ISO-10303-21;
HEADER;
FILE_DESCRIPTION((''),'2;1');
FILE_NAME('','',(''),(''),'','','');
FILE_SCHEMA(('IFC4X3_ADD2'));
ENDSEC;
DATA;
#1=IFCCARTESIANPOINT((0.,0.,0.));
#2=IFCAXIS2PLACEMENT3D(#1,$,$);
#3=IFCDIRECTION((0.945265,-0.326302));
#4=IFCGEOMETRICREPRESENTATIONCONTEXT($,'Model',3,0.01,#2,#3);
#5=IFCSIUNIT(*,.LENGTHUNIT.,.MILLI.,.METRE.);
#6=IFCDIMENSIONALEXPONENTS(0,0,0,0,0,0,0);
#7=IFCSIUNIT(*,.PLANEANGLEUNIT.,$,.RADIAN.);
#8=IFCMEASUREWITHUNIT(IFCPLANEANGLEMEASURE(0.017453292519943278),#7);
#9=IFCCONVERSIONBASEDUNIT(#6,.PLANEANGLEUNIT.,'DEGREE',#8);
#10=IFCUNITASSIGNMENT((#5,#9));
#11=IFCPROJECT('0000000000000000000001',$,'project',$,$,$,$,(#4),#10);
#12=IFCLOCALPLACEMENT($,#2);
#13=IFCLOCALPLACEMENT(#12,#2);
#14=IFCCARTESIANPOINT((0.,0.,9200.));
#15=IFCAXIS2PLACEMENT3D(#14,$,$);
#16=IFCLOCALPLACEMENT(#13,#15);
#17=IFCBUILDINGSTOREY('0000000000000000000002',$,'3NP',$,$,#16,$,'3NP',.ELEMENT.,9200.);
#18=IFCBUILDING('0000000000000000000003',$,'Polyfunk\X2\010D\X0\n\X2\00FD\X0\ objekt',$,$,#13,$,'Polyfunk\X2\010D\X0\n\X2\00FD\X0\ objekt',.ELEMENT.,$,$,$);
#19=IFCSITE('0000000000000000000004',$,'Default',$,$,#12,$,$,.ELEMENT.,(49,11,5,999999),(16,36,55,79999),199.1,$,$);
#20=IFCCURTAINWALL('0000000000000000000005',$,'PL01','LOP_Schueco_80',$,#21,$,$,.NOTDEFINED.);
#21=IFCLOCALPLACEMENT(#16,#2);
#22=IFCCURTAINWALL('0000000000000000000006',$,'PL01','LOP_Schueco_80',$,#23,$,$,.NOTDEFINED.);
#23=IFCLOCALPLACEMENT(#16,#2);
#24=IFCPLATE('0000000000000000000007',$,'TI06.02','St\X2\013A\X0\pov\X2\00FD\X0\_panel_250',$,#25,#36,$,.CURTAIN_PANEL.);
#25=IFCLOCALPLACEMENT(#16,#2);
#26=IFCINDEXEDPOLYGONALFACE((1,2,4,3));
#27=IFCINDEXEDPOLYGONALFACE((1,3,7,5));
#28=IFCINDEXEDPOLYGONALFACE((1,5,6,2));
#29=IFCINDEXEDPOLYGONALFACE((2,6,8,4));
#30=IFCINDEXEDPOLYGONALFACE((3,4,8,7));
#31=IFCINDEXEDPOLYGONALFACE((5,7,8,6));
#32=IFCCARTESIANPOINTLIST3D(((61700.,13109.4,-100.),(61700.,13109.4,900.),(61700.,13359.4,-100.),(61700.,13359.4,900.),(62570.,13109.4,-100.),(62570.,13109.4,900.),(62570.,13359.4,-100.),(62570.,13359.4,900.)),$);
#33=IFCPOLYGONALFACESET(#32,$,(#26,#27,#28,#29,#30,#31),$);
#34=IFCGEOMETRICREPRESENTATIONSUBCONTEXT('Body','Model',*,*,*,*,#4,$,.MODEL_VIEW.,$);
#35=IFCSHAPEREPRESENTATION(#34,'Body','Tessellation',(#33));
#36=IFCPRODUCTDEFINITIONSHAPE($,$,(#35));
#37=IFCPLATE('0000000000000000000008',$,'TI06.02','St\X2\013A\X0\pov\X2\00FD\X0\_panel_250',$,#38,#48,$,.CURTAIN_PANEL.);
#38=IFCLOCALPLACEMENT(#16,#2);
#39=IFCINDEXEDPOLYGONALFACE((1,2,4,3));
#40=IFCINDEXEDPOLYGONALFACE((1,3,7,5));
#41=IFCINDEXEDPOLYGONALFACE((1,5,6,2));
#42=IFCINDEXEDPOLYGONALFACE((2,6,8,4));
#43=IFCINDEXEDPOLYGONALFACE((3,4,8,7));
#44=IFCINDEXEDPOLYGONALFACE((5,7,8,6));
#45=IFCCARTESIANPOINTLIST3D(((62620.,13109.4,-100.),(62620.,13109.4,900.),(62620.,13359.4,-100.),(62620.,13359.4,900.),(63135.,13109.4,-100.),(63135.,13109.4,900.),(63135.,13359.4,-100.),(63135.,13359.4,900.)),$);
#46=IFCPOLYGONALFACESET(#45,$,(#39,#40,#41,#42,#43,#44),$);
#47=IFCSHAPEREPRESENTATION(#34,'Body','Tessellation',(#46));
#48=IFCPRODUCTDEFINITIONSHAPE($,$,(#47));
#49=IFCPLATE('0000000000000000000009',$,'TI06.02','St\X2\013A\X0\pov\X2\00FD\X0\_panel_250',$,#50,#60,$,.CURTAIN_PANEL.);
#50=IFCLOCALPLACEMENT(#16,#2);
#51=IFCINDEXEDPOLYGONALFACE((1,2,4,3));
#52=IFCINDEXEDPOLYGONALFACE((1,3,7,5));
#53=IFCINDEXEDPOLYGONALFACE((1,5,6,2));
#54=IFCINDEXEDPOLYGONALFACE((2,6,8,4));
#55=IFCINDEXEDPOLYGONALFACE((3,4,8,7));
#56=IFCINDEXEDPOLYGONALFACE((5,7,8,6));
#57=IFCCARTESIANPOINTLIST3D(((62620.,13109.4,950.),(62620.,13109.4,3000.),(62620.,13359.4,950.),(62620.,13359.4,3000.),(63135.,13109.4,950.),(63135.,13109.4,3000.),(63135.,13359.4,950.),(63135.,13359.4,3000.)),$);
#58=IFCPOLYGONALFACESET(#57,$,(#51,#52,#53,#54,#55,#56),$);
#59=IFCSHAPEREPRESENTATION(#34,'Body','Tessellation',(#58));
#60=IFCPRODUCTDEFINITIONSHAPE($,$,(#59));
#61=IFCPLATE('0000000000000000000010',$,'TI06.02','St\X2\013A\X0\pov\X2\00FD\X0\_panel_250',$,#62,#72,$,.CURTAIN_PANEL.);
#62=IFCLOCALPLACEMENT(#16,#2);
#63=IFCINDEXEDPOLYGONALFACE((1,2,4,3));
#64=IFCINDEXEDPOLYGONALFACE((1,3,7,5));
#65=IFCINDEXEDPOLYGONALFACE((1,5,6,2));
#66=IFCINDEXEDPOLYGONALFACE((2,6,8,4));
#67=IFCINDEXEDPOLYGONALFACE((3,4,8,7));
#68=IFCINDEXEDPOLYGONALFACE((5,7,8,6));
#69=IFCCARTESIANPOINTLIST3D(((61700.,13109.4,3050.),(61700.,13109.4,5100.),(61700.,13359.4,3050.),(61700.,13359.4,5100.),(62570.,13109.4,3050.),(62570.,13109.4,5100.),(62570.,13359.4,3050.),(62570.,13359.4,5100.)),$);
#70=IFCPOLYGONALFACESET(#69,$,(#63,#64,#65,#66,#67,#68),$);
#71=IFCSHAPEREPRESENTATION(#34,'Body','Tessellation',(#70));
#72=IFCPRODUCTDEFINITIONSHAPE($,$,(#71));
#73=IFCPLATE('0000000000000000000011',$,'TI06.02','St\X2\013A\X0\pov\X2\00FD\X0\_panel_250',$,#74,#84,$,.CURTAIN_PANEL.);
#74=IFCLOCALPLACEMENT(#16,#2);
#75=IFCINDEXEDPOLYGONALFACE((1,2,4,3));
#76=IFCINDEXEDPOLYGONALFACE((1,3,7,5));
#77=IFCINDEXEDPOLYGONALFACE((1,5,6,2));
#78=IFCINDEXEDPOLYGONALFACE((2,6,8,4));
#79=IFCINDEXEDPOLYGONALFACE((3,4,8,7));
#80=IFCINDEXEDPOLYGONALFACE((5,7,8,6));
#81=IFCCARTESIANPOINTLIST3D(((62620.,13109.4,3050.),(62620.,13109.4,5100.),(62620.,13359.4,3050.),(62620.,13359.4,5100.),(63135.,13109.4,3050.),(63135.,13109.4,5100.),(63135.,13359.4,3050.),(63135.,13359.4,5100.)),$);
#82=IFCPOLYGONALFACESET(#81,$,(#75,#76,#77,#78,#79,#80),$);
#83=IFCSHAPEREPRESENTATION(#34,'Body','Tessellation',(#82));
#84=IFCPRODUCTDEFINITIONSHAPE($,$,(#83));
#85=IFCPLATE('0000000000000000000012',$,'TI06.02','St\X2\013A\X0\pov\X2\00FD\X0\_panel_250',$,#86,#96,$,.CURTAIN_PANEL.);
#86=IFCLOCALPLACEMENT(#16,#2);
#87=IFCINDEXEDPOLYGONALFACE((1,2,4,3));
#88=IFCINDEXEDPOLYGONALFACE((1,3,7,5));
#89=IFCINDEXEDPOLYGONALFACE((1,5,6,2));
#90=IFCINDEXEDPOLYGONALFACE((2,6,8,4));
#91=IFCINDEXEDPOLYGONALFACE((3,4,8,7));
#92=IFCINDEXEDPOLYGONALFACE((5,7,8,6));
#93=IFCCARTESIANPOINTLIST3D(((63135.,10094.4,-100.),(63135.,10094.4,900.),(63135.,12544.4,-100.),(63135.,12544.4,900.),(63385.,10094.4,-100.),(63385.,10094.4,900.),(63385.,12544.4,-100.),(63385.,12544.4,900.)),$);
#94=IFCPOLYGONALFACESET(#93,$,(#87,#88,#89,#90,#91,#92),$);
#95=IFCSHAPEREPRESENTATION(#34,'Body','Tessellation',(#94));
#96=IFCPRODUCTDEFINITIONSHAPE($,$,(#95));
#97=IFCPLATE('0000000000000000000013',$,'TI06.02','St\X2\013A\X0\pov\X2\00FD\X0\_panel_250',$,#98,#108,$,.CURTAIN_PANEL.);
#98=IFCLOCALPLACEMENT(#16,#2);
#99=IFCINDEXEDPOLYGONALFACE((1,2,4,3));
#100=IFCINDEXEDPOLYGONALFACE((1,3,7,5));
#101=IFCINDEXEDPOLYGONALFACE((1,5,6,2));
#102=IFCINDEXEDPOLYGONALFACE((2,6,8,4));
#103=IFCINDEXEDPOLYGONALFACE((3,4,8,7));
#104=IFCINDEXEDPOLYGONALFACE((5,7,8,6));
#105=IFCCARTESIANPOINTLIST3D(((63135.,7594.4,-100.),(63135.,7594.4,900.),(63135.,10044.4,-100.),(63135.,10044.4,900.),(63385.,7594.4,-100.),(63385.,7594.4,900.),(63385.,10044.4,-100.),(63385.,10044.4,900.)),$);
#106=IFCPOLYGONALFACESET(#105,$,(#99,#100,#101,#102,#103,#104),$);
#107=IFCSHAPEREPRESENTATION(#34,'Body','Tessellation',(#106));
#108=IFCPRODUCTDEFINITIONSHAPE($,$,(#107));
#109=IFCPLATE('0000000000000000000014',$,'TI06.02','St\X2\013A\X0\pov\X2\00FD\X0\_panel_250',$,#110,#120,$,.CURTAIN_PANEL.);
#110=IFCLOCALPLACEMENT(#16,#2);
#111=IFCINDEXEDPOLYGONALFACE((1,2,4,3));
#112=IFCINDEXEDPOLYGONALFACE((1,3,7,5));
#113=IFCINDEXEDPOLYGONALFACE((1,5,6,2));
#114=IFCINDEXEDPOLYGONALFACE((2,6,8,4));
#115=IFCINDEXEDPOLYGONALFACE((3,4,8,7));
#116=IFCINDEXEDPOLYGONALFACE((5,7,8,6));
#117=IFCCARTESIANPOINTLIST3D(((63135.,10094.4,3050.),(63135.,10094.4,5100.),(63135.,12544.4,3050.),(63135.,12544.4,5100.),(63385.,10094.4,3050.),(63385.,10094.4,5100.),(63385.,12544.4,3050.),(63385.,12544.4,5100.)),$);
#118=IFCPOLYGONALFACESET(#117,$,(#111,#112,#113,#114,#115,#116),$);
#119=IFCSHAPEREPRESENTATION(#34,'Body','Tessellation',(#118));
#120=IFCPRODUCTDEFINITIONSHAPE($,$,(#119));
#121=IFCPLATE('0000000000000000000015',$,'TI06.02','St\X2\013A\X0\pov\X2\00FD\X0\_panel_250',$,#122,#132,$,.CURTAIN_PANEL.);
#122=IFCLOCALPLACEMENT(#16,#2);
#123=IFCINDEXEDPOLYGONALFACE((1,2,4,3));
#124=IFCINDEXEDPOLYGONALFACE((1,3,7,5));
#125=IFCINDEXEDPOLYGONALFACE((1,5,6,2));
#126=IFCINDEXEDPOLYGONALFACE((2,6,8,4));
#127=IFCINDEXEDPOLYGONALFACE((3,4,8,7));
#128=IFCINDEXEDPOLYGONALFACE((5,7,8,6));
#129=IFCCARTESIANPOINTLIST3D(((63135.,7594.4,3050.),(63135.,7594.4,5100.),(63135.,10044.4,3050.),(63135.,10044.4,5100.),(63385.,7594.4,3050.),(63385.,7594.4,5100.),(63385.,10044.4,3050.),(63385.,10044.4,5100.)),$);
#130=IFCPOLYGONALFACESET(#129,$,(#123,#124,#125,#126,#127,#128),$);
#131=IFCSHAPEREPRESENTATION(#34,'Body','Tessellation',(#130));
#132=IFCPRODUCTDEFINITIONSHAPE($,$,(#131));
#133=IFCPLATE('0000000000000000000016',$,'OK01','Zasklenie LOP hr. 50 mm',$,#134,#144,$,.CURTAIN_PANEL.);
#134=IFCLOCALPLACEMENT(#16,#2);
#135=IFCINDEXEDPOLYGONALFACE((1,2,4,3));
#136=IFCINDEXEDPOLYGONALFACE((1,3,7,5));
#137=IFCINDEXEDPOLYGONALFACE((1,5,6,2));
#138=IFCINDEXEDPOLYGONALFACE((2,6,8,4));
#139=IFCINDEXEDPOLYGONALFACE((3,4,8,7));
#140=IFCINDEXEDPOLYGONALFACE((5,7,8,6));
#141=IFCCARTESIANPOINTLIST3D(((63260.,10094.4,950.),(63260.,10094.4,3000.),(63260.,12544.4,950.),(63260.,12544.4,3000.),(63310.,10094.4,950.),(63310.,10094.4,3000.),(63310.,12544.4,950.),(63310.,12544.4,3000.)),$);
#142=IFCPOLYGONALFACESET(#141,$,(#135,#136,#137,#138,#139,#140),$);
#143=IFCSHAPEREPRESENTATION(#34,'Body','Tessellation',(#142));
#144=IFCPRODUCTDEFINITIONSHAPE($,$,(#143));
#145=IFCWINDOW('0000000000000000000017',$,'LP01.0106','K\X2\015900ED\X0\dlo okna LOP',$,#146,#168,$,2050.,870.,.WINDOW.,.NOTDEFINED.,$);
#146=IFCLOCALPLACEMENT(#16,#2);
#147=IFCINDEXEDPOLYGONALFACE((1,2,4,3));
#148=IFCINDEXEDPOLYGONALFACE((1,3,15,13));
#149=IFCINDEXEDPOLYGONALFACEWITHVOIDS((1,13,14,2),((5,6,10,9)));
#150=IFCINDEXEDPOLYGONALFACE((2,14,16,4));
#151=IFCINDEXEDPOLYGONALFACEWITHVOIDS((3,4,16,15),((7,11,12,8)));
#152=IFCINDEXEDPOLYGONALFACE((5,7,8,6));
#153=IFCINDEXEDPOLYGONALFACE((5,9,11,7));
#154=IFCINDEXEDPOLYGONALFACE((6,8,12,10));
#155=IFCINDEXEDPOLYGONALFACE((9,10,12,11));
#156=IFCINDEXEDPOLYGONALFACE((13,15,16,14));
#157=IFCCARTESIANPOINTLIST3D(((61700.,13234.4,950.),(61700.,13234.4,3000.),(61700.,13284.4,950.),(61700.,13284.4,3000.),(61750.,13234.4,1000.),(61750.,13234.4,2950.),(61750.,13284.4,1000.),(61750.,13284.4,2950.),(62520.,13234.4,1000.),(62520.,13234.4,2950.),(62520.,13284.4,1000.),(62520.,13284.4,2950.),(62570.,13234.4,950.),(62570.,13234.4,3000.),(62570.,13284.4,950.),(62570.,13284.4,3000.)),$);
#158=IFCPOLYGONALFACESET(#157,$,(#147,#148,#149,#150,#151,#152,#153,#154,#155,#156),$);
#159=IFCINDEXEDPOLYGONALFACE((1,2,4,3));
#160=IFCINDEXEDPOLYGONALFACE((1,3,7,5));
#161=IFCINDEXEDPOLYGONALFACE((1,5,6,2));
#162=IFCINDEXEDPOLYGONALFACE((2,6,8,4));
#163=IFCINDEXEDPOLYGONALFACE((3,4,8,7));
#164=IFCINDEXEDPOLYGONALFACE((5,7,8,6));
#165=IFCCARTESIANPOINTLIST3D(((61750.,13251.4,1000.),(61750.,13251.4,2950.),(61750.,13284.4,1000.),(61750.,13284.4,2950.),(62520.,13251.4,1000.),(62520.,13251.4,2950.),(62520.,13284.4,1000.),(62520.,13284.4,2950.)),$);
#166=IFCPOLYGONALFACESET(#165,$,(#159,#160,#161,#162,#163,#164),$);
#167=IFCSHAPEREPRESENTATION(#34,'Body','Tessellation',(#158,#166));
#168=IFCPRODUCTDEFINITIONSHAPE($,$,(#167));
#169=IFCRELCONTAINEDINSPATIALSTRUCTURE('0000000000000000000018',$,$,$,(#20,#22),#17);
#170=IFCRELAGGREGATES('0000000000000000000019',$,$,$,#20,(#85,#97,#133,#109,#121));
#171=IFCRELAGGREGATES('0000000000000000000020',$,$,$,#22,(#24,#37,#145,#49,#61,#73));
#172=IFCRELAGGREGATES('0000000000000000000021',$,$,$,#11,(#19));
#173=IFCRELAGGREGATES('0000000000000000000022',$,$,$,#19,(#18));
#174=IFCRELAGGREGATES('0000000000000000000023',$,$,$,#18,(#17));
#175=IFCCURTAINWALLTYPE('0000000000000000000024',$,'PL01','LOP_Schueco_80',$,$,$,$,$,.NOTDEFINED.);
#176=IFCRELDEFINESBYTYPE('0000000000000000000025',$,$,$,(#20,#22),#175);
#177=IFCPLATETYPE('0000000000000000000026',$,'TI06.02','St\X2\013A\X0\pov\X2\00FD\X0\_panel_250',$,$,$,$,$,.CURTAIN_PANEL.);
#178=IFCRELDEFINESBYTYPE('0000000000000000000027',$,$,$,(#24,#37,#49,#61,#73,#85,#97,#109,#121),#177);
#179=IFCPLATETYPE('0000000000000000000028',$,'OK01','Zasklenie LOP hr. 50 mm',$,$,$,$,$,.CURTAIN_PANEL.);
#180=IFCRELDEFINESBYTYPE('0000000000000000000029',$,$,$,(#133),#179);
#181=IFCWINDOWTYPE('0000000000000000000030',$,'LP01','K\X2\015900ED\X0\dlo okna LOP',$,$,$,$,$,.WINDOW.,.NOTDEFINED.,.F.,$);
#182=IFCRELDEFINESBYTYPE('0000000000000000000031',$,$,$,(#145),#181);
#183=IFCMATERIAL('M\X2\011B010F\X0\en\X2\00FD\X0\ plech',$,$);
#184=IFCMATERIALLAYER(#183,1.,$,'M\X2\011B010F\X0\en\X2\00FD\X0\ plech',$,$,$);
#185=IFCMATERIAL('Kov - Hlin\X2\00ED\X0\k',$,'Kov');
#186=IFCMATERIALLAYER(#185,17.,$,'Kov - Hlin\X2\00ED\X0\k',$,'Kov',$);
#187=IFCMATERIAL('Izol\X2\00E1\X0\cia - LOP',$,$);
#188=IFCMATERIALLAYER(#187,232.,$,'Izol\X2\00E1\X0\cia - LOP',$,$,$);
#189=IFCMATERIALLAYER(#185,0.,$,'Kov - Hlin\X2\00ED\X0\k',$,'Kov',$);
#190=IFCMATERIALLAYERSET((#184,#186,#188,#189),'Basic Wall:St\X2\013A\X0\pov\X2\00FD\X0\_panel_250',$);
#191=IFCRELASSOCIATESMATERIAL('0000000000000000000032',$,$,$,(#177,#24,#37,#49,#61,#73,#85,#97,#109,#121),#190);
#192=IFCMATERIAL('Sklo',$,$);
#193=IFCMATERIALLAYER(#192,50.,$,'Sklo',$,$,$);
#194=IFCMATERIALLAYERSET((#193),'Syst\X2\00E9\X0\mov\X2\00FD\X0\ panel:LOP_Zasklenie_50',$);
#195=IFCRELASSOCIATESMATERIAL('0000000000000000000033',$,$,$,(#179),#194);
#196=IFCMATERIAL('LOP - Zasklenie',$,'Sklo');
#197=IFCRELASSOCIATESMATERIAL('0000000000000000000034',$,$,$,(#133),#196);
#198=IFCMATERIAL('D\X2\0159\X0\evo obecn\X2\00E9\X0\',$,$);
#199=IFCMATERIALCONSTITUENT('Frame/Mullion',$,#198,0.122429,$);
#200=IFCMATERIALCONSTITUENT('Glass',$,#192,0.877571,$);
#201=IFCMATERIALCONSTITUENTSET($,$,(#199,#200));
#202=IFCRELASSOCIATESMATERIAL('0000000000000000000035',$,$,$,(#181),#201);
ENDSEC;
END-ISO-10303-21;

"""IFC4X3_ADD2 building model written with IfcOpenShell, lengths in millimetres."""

from ifc_helpers import new_model, entity, si_unit, converted_unit, direction, frame, frame_2d, origin, origin_2d_with_axis, place, context, subcontext, project, spatial, polyline, rectangle, outline, extrude, source, transform, mapped, material, layer, layer_set, layer_usage, constituent, constituent_set, type_object, type_shapes, element, aggregate, save


model = new_model("IFC4X3_ADD2")

# Units and contexts
model_context = context("Model", 3, precision=0.01, world=origin(), true_north=direction((0.945265, -0.326302)))
body_context = subcontext(model_context, "Body", "Model", "MODEL_VIEW")
ifc_project = project(units=[si_unit("LENGTHUNIT", "METRE", prefix="MILLI"), converted_unit("PLANEANGLEUNIT", "DEGREE", entity("IfcPlaneAngleMeasure", 0.017453292519943278), si_unit("PLANEANGLEUNIT", "RADIAN"), dimensions=[0, 0, 0, 0, 0, 0, 0])], contexts=[model_context])

# Site, building, storey
site_placement = place(None, origin())
site = spatial("IfcSite", under=ifc_project, at=site_placement, Name="Default", CompositionType="ELEMENT", RefLatitude=(49, 11, 5, 999999), RefLongitude=(16, 36, 55, 79999), RefElevation=199.1)
building_placement = place(site_placement, origin())
building = spatial("IfcBuilding", under=site, at=building_placement, Name="Polyfunkčný objekt", LongName="Polyfunkčný objekt", CompositionType="ELEMENT")
storey_placement = place(building_placement, frame((0.0, 0.0, 9200.0)))
storey = spatial("IfcBuildingStorey", under=building, at=storey_placement, Name="3NP", LongName="3NP", CompositionType="ELEMENT", Elevation=9200.0)

# Curtain walls
curtain_wall_type = type_object("IfcCurtainWallType", Name="PL01", Description="LOP_Schueco_80", PredefinedType="NOTDEFINED")
curtain_wall_1_placement = place(storey_placement, frame((0.0, 0.0, -9200.0)))
curtain_wall_1 = element("IfcCurtainWall", 1, at=curtain_wall_1_placement, inside=storey, type_object=curtain_wall_type, Name="PL01", Description="LOP_Schueco_80", PredefinedType="NOTDEFINED")
curtain_wall_2_placement = place(storey_placement, frame((0.0, 0.0, -9200.0)))
curtain_wall_2 = element("IfcCurtainWall", 2, at=curtain_wall_2_placement, inside=storey, type_object=curtain_wall_type, Name="PL01", Description="LOP_Schueco_80", PredefinedType="NOTDEFINED")

# Plates
ifc_material_1 = material(Name="Měďený plech")
ifc_layer_1 = layer(ifc_material_1, 1.0, Name="Měďený plech")
ifc_material_2 = material(Name="Kov - Hliník", Category="Kov")
ifc_layer_2 = layer(ifc_material_2, 17.0, Name="Kov - Hliník", Category="Kov")
ifc_material_3 = material(Name="Izolácia - LOP")
ifc_layer_3 = layer(ifc_material_3, 232.0, Name="Izolácia - LOP")
ifc_layer_4 = layer(ifc_material_2, 0.0, Name="Kov - Hliník", Category="Kov")
ifc_layer_set_1 = layer_set([ifc_layer_1, ifc_layer_2, ifc_layer_3, ifc_layer_4], Name="Basic Wall:Stĺpový_panel_250")
ifc_layer_usage_1 = layer_usage(ifc_layer_set_1, "AXIS2", "NEGATIVE", 125.0)
plate_type_1 = type_object("IfcPlateType", Name="TI06.02", Description="Stĺpový_panel_250", PredefinedType="CURTAIN_PANEL", material=ifc_layer_set_1)
plate_1_placement = place(storey_placement, frame((61700.0, 13234.4, -100.0)))
plate_1 = element("IfcPlate", 3, at=plate_1_placement, type_object=plate_type_1, material=ifc_layer_usage_1, Name="TI06.02", Description="Stĺpový_panel_250", PredefinedType="CURTAIN_PANEL", context=body_context, shape_type="SweptSolid", body=[
    extrude(rectangle(XDim=250.0, YDim=870.0, at=frame_2d((0.0, 0.0), x_axis=(1.0, 0.0))), frame((435.0, 0.0, 0.0), z_axis=(0.0, 0.0, 1.0), x_axis=(0.0, 1.0, 0.0)), (0.0, 0.0, 1.0), 1000.0),
])
ifc_layer_usage_2 = layer_usage(ifc_layer_set_1, "AXIS2", "NEGATIVE", 125.0)
plate_2_placement = place(storey_placement, frame((62620.0, 13234.4, -100.0)))
plate_2 = element("IfcPlate", 4, at=plate_2_placement, type_object=plate_type_1, material=ifc_layer_usage_2, Name="TI06.02", Description="Stĺpový_panel_250", PredefinedType="CURTAIN_PANEL", context=body_context, shape_type="SweptSolid", body=[
    extrude(rectangle(XDim=250.0, YDim=515.0, at=frame_2d((0.0, 0.0), x_axis=(1.0, 0.0))), frame((257.5, 0.0, 0.0), z_axis=(0.0, 0.0, 1.0), x_axis=(0.0, 1.0, 0.0)), (0.0, 0.0, 1.0), 1000.0),
])
ifc_layer_usage_3 = layer_usage(ifc_layer_set_1, "AXIS2", "NEGATIVE", 125.0)
plate_3_placement = place(storey_placement, frame((62620.0, 13234.4, 950.0)))
plate_3 = element("IfcPlate", 5, at=plate_3_placement, type_object=plate_type_1, material=ifc_layer_usage_3, Name="TI06.02", Description="Stĺpový_panel_250", PredefinedType="CURTAIN_PANEL", context=body_context, shape_type="SweptSolid", body=[
    extrude(rectangle(XDim=250.0, YDim=515.0, at=frame_2d((0.0, 0.0), x_axis=(1.0, 0.0))), frame((257.5, 0.0, 0.0), z_axis=(0.0, 0.0, 1.0), x_axis=(0.0, 1.0, 0.0)), (0.0, 0.0, 1.0), 2050.0),
])
ifc_layer_usage_4 = layer_usage(ifc_layer_set_1, "AXIS2", "NEGATIVE", 125.0)
plate_4_placement = place(storey_placement, frame((61700.0, 13234.4, 3050.0)))
plate_4 = element("IfcPlate", 6, at=plate_4_placement, type_object=plate_type_1, material=ifc_layer_usage_4, Name="TI06.02", Description="Stĺpový_panel_250", PredefinedType="CURTAIN_PANEL", context=body_context, shape_type="SweptSolid", body=[
    extrude(rectangle(XDim=250.0, YDim=870.0, at=frame_2d((0.0, 0.0), x_axis=(1.0, 0.0))), frame((435.0, 0.0, 0.0), z_axis=(0.0, 0.0, 1.0), x_axis=(0.0, 1.0, 0.0)), (0.0, 0.0, 1.0), 2050.0),
])
ifc_layer_usage_5 = layer_usage(ifc_layer_set_1, "AXIS2", "NEGATIVE", 125.0)
plate_5_placement = place(storey_placement, frame((62620.0, 13234.4, 3050.0)))
plate_5 = element("IfcPlate", 7, at=plate_5_placement, type_object=plate_type_1, material=ifc_layer_usage_5, Name="TI06.02", Description="Stĺpový_panel_250", PredefinedType="CURTAIN_PANEL", context=body_context, shape_type="SweptSolid", body=[
    extrude(rectangle(XDim=250.0, YDim=515.0, at=frame_2d((0.0, 0.0), x_axis=(1.0, 0.0))), frame((257.5, 0.0, 0.0), z_axis=(0.0, 0.0, 1.0), x_axis=(0.0, 1.0, 0.0)), (0.0, 0.0, 1.0), 2050.0),
])
ifc_layer_usage_6 = layer_usage(ifc_layer_set_1, "AXIS2", "NEGATIVE", 125.0)
plate_6_placement = place(storey_placement, frame((63260.0, 12544.4, -100.0), z_axis=(0.0, 0.0, 1.0), x_axis=(0.0, -1.0, 0.0)))
plate_6 = element("IfcPlate", 8, at=plate_6_placement, type_object=plate_type_1, material=ifc_layer_usage_6, Name="TI06.02", Description="Stĺpový_panel_250", PredefinedType="CURTAIN_PANEL", context=body_context, shape_type="SweptSolid", body=[
    extrude(rectangle(XDim=250.0, YDim=2450.0, at=frame_2d((0.0, 0.0), x_axis=(1.0, 0.0))), frame((1225.0, 0.0, 0.0), z_axis=(0.0, 0.0, 1.0), x_axis=(0.0, 1.0, 0.0)), (0.0, 0.0, 1.0), 1000.0),
])
ifc_layer_usage_7 = layer_usage(ifc_layer_set_1, "AXIS2", "NEGATIVE", 125.0)
plate_7_placement = place(storey_placement, frame((63260.0, 10044.4, -100.0), z_axis=(0.0, 0.0, 1.0), x_axis=(0.0, -1.0, 0.0)))
plate_7 = element("IfcPlate", 9, at=plate_7_placement, type_object=plate_type_1, material=ifc_layer_usage_7, Name="TI06.02", Description="Stĺpový_panel_250", PredefinedType="CURTAIN_PANEL", context=body_context, shape_type="SweptSolid", body=[
    extrude(rectangle(XDim=250.0, YDim=2450.0, at=origin_2d_with_axis()), frame((1225.0, 0.0, 0.0), z_axis=(0.0, 0.0, 1.0), x_axis=(0.0, 1.0, 0.0)), (0.0, 0.0, 1.0), 1000.0),
])
ifc_layer_usage_8 = layer_usage(ifc_layer_set_1, "AXIS2", "NEGATIVE", 125.0)
plate_8_placement = place(storey_placement, frame((63260.0, 12544.4, 3050.0), z_axis=(0.0, 0.0, 1.0), x_axis=(0.0, -1.0, 0.0)))
plate_8 = element("IfcPlate", 10, at=plate_8_placement, type_object=plate_type_1, material=ifc_layer_usage_8, Name="TI06.02", Description="Stĺpový_panel_250", PredefinedType="CURTAIN_PANEL", context=body_context, shape_type="SweptSolid", body=[
    extrude(rectangle(XDim=250.0, YDim=2450.0, at=frame_2d((0.0, 0.0), x_axis=(1.0, 0.0))), frame((1225.0, 0.0, 0.0), z_axis=(0.0, 0.0, 1.0), x_axis=(0.0, 1.0, 0.0)), (0.0, 0.0, 1.0), 2050.0),
])
ifc_layer_usage_9 = layer_usage(ifc_layer_set_1, "AXIS2", "NEGATIVE", 125.0)
plate_9_placement = place(storey_placement, frame((63260.0, 10044.4, 3050.0), z_axis=(0.0, 0.0, 1.0), x_axis=(0.0, -1.0, 0.0)))
plate_9 = element("IfcPlate", 11, at=plate_9_placement, type_object=plate_type_1, material=ifc_layer_usage_9, Name="TI06.02", Description="Stĺpový_panel_250", PredefinedType="CURTAIN_PANEL", context=body_context, shape_type="SweptSolid", body=[
    extrude(rectangle(XDim=250.0, YDim=2450.0, at=frame_2d((0.0, 0.0), x_axis=(1.0, 0.0))), frame((1225.0, 0.0, 0.0), z_axis=(0.0, 0.0, 1.0), x_axis=(0.0, 1.0, 0.0)), (0.0, 0.0, 1.0), 2050.0),
])
ifc_material_4 = material(Name="LOP - Zasklenie", Category="Sklo")
ifc_material_5 = material(Name="Sklo")
ifc_layer_5 = layer(ifc_material_5, 50.0, Name="Sklo")
ifc_layer_set_2 = layer_set([ifc_layer_5], Name="Systémový panel:LOP_Zasklenie_50")
plate_type_2 = type_object("IfcPlateType", Name="OK01", Description="Zasklenie LOP hr. 50 mm", PredefinedType="CURTAIN_PANEL", material=ifc_layer_set_2)
shared_shape_1 = source(origin(), body_context, "Body", "SweptSolid", [
    extrude(rectangle(XDim=50.0, YDim=2450.0, at=origin_2d_with_axis()), frame((0.0, 25.0, 0.0), z_axis=(0.0, 0.0, 1.0), x_axis=(0.0, 1.0, 0.0)), (0.0, 0.0, 1.0), 2050.0),
])
type_shapes(plate_type_2, [shared_shape_1])
plate_10_placement = place(curtain_wall_1_placement, frame((63260.0, 11319.4, 10150.0), z_axis=(0.0, 0.0, 1.0), x_axis=(0.0, -1.0, 0.0)))
plate_10 = element("IfcPlate", 12, at=plate_10_placement, type_object=plate_type_2, material=ifc_material_4, Name="OK01", Description="Zasklenie LOP hr. 50 mm", PredefinedType="CURTAIN_PANEL", context=body_context, shape_type="MappedRepresentation", body=[
    mapped(shared_shape_1, transform((0.0, 0.0, 0.0), scale=1.0)),
])
aggregate(curtain_wall_1, [plate_6, plate_7, plate_10, plate_8, plate_9])

# Window
ifc_material_6 = material(Name="Dřevo obecné")
ifc_constituent_1 = constituent(ifc_material_6, Name="Frame/Mullion", fraction=0.122429)
ifc_constituent_2 = constituent(ifc_material_5, Name="Glass", fraction=0.877571)
ifc_constituent_set = constituent_set(constituents=[ifc_constituent_1, ifc_constituent_2])
window_type = type_object("IfcWindowType", Name="LP01", Description="Křídlo okna LOP", ParameterTakesPrecedence=False, PartitioningType="NOTDEFINED", PredefinedType="WINDOW", material=ifc_constituent_set)
shared_shape_2 = source(origin(), body_context, "Body", "SweptSolid", [
    extrude(outline(polyline([(-1025.0, -435.0), (1025.0, -435.0), (1025.0, 435.0), (-1025.0, 435.0), (-1025.0, -435.0)]), holes=[polyline([(-975.0, -385.0), (-975.0, 385.0), (975.0, 385.0), (975.0, -385.0), (-975.0, -385.0)])]), frame((0.0, 0.0, 1025.0), z_axis=(0.0, 1.0, 0.0), x_axis=(0.0, 0.0, -1.0)), (0.0, 0.0, 1.0), 50.0),
    extrude(rectangle(XDim=33.0, YDim=770.0, at=origin_2d_with_axis()), frame((0.0, 33.5, 50.0), z_axis=(0.0, 0.0, 1.0), x_axis=(0.0, -1.0, 0.0)), (0.0, 0.0, 1.0), 1950.0),
])
type_shapes(window_type, [shared_shape_2])
window_placement = place(curtain_wall_2_placement, frame((62135.0, 13234.4, 10150.0)))
window = element("IfcWindow", 13, at=window_placement, type_object=window_type, Name="LP01.0106", Description="Křídlo okna LOP", OverallHeight=2050.0, OverallWidth=870.0, PartitioningType="NOTDEFINED", PredefinedType="WINDOW", context=body_context, shape_type="MappedRepresentation", body=[
    mapped(shared_shape_2, transform((0.0, 0.0, 0.0), scale=1.0)),
])
aggregate(curtain_wall_2, [plate_1, plate_2, window, plate_3, plate_4, plate_5])

save(model, "model.ifc")
